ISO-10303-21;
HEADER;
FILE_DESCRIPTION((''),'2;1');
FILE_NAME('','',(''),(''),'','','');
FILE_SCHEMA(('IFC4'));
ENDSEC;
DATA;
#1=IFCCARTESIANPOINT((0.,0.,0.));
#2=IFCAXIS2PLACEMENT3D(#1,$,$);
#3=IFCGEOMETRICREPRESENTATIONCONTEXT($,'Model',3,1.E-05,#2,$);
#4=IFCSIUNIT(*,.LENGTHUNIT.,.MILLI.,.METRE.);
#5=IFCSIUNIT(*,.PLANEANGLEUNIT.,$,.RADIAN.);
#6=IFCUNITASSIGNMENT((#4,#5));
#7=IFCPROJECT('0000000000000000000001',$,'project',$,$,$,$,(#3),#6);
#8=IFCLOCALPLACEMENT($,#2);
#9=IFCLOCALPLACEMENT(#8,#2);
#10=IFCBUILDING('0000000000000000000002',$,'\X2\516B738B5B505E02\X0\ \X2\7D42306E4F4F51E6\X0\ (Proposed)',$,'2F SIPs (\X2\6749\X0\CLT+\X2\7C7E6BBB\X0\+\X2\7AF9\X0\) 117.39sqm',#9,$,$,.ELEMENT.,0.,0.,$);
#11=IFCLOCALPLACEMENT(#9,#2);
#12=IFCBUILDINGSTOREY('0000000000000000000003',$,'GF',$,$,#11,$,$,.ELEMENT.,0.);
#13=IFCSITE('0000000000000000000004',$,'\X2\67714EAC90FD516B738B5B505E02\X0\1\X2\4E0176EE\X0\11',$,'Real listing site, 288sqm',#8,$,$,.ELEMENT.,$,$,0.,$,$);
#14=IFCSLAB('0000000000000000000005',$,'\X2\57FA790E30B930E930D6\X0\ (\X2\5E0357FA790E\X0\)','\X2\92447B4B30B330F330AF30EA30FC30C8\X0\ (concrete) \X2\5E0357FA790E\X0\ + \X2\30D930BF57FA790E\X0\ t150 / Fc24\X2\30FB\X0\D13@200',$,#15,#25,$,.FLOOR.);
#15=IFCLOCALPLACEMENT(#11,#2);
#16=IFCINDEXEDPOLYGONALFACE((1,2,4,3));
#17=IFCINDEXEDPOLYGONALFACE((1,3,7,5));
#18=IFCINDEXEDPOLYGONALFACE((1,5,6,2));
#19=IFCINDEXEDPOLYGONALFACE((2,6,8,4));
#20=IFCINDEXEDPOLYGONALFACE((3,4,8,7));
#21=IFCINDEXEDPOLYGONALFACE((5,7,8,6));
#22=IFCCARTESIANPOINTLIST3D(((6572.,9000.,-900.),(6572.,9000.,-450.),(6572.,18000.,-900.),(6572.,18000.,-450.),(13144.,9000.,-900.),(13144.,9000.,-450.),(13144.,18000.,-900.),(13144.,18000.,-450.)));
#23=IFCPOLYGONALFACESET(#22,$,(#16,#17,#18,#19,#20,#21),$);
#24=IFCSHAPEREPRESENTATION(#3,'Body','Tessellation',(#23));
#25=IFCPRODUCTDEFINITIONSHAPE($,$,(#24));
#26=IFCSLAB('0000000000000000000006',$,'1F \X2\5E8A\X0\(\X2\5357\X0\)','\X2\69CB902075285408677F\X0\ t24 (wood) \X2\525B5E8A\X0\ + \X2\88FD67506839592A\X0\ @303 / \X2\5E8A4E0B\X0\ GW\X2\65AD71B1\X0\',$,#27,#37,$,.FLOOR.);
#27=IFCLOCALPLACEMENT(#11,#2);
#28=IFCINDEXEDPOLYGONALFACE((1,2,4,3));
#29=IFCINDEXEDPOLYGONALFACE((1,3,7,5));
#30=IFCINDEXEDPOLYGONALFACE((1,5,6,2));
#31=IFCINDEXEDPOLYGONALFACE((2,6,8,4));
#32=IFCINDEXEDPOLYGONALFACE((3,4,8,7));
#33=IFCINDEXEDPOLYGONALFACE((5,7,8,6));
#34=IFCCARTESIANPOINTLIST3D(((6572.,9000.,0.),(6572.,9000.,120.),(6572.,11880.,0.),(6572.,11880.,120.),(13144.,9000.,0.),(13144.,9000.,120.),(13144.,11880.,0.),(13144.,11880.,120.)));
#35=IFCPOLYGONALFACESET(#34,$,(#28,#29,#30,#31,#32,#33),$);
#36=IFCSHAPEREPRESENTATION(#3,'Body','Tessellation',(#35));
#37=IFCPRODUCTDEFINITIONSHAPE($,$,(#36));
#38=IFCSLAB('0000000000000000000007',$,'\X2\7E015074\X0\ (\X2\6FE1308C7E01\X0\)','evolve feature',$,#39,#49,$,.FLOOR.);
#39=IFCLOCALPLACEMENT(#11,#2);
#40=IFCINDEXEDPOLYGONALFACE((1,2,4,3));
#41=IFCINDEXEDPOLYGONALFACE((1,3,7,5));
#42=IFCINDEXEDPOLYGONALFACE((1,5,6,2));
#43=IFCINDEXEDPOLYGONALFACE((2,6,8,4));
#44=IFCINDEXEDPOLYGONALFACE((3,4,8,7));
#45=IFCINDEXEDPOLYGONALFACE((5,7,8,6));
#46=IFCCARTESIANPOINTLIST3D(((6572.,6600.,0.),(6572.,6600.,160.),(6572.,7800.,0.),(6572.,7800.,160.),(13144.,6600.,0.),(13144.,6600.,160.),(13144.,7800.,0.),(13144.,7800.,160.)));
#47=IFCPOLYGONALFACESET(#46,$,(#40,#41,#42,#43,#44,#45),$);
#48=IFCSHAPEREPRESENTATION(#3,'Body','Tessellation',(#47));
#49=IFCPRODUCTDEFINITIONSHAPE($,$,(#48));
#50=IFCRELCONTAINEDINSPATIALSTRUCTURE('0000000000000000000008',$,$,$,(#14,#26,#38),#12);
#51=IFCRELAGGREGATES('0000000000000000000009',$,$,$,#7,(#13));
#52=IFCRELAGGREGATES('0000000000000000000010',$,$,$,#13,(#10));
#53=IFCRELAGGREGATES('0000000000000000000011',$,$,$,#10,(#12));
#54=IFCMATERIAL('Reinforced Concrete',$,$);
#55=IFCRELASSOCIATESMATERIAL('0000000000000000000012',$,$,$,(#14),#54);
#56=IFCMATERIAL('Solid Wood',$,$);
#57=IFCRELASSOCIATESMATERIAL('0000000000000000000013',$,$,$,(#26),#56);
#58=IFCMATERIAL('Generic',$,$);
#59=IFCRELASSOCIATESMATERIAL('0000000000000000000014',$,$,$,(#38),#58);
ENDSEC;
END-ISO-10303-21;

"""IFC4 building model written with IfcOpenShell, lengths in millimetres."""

from ifc_helpers import new_model, si_unit, frame, frame_2d, origin, place, context, project, spatial, rectangle, extrude, material, element, save


model = new_model("IFC4")

# Units and contexts
model_context = context("Model", 3, precision=1e-05, world=origin())
ifc_project = project(units=[si_unit("LENGTHUNIT", "METRE", prefix="MILLI"), si_unit("PLANEANGLEUNIT", "RADIAN")], contexts=[model_context])

# Site, building, storey
site_placement = place(None, origin())
site = spatial("IfcSite", under=ifc_project, at=site_placement, Name="東京都八王子市1丁目11", ObjectType="Real listing site, 288sqm", CompositionType="ELEMENT", RefElevation=0.0)
building_placement = place(site_placement, origin())
building = spatial("IfcBuilding", under=site, at=building_placement, Name="八王子市 終の住処 (Proposed)", ObjectType="2F SIPs (杉CLT+籾殻+竹) 117.39sqm", CompositionType="ELEMENT", ElevationOfRefHeight=0.0, ElevationOfTerrain=0.0)
storey_placement = place(building_placement, origin())
storey = spatial("IfcBuildingStorey", under=building, at=storey_placement, Name="GF", CompositionType="ELEMENT", Elevation=0.0)

# Slabs
ifc_material_1 = material(Name="Reinforced Concrete")
slab_1_placement = place(storey_placement, frame((3286.0, 4500.0, -450.0)))
element("IfcSlab", 1, at=slab_1_placement, inside=storey, material=ifc_material_1, Name="基礎スラブ (布基礎)", Description="鉄筋コンクリート (concrete) 布基礎 + ベタ基礎 t150 / Fc24・D13@200", PredefinedType="FLOOR", context=model_context, shape_type="SweptSolid", body=[
    extrude(rectangle(XDim=6572.0, YDim=9000.0, at=frame_2d((3286.0, 4500.0))), frame((3286.0, 4500.0, -450.0)), (0.0, 0.0, 1.0), 450.0),
])
ifc_material_2 = material(Name="Solid Wood")
slab_2_placement = place(storey_placement, frame((3286.0, 4500.0, 0.0)))
element("IfcSlab", 2, at=slab_2_placement, inside=storey, material=ifc_material_2, Name="1F 床(南)", Description="構造用合板 t24 (wood) 剛床 + 製材根太 @303 / 床下 GW断熱", PredefinedType="FLOOR", context=model_context, shape_type="SweptSolid", body=[
    extrude(rectangle(XDim=6572.0, YDim=2880.0, at=frame_2d((3286.0, 1440.0))), frame((3286.0, 4500.0, 0.0)), (0.0, 0.0, 1.0), 120.0),
])
ifc_material_3 = material(Name="Generic")
slab_3_placement = place(storey_placement, frame((3286.0, 3300.0, 0.0)))
element("IfcSlab", 3, at=slab_3_placement, inside=storey, material=ifc_material_3, Name="縁側 (濡れ縁)", Description="evolve feature", PredefinedType="FLOOR", context=model_context, shape_type="SweptSolid", body=[
    extrude(rectangle(XDim=6572.0, YDim=1200.0, at=frame_2d((3286.0, 600.0))), frame((3286.0, 3300.0, 0.0)), (0.0, 0.0, 1.0), 160.0),
])

save(model, "model.ifc")
